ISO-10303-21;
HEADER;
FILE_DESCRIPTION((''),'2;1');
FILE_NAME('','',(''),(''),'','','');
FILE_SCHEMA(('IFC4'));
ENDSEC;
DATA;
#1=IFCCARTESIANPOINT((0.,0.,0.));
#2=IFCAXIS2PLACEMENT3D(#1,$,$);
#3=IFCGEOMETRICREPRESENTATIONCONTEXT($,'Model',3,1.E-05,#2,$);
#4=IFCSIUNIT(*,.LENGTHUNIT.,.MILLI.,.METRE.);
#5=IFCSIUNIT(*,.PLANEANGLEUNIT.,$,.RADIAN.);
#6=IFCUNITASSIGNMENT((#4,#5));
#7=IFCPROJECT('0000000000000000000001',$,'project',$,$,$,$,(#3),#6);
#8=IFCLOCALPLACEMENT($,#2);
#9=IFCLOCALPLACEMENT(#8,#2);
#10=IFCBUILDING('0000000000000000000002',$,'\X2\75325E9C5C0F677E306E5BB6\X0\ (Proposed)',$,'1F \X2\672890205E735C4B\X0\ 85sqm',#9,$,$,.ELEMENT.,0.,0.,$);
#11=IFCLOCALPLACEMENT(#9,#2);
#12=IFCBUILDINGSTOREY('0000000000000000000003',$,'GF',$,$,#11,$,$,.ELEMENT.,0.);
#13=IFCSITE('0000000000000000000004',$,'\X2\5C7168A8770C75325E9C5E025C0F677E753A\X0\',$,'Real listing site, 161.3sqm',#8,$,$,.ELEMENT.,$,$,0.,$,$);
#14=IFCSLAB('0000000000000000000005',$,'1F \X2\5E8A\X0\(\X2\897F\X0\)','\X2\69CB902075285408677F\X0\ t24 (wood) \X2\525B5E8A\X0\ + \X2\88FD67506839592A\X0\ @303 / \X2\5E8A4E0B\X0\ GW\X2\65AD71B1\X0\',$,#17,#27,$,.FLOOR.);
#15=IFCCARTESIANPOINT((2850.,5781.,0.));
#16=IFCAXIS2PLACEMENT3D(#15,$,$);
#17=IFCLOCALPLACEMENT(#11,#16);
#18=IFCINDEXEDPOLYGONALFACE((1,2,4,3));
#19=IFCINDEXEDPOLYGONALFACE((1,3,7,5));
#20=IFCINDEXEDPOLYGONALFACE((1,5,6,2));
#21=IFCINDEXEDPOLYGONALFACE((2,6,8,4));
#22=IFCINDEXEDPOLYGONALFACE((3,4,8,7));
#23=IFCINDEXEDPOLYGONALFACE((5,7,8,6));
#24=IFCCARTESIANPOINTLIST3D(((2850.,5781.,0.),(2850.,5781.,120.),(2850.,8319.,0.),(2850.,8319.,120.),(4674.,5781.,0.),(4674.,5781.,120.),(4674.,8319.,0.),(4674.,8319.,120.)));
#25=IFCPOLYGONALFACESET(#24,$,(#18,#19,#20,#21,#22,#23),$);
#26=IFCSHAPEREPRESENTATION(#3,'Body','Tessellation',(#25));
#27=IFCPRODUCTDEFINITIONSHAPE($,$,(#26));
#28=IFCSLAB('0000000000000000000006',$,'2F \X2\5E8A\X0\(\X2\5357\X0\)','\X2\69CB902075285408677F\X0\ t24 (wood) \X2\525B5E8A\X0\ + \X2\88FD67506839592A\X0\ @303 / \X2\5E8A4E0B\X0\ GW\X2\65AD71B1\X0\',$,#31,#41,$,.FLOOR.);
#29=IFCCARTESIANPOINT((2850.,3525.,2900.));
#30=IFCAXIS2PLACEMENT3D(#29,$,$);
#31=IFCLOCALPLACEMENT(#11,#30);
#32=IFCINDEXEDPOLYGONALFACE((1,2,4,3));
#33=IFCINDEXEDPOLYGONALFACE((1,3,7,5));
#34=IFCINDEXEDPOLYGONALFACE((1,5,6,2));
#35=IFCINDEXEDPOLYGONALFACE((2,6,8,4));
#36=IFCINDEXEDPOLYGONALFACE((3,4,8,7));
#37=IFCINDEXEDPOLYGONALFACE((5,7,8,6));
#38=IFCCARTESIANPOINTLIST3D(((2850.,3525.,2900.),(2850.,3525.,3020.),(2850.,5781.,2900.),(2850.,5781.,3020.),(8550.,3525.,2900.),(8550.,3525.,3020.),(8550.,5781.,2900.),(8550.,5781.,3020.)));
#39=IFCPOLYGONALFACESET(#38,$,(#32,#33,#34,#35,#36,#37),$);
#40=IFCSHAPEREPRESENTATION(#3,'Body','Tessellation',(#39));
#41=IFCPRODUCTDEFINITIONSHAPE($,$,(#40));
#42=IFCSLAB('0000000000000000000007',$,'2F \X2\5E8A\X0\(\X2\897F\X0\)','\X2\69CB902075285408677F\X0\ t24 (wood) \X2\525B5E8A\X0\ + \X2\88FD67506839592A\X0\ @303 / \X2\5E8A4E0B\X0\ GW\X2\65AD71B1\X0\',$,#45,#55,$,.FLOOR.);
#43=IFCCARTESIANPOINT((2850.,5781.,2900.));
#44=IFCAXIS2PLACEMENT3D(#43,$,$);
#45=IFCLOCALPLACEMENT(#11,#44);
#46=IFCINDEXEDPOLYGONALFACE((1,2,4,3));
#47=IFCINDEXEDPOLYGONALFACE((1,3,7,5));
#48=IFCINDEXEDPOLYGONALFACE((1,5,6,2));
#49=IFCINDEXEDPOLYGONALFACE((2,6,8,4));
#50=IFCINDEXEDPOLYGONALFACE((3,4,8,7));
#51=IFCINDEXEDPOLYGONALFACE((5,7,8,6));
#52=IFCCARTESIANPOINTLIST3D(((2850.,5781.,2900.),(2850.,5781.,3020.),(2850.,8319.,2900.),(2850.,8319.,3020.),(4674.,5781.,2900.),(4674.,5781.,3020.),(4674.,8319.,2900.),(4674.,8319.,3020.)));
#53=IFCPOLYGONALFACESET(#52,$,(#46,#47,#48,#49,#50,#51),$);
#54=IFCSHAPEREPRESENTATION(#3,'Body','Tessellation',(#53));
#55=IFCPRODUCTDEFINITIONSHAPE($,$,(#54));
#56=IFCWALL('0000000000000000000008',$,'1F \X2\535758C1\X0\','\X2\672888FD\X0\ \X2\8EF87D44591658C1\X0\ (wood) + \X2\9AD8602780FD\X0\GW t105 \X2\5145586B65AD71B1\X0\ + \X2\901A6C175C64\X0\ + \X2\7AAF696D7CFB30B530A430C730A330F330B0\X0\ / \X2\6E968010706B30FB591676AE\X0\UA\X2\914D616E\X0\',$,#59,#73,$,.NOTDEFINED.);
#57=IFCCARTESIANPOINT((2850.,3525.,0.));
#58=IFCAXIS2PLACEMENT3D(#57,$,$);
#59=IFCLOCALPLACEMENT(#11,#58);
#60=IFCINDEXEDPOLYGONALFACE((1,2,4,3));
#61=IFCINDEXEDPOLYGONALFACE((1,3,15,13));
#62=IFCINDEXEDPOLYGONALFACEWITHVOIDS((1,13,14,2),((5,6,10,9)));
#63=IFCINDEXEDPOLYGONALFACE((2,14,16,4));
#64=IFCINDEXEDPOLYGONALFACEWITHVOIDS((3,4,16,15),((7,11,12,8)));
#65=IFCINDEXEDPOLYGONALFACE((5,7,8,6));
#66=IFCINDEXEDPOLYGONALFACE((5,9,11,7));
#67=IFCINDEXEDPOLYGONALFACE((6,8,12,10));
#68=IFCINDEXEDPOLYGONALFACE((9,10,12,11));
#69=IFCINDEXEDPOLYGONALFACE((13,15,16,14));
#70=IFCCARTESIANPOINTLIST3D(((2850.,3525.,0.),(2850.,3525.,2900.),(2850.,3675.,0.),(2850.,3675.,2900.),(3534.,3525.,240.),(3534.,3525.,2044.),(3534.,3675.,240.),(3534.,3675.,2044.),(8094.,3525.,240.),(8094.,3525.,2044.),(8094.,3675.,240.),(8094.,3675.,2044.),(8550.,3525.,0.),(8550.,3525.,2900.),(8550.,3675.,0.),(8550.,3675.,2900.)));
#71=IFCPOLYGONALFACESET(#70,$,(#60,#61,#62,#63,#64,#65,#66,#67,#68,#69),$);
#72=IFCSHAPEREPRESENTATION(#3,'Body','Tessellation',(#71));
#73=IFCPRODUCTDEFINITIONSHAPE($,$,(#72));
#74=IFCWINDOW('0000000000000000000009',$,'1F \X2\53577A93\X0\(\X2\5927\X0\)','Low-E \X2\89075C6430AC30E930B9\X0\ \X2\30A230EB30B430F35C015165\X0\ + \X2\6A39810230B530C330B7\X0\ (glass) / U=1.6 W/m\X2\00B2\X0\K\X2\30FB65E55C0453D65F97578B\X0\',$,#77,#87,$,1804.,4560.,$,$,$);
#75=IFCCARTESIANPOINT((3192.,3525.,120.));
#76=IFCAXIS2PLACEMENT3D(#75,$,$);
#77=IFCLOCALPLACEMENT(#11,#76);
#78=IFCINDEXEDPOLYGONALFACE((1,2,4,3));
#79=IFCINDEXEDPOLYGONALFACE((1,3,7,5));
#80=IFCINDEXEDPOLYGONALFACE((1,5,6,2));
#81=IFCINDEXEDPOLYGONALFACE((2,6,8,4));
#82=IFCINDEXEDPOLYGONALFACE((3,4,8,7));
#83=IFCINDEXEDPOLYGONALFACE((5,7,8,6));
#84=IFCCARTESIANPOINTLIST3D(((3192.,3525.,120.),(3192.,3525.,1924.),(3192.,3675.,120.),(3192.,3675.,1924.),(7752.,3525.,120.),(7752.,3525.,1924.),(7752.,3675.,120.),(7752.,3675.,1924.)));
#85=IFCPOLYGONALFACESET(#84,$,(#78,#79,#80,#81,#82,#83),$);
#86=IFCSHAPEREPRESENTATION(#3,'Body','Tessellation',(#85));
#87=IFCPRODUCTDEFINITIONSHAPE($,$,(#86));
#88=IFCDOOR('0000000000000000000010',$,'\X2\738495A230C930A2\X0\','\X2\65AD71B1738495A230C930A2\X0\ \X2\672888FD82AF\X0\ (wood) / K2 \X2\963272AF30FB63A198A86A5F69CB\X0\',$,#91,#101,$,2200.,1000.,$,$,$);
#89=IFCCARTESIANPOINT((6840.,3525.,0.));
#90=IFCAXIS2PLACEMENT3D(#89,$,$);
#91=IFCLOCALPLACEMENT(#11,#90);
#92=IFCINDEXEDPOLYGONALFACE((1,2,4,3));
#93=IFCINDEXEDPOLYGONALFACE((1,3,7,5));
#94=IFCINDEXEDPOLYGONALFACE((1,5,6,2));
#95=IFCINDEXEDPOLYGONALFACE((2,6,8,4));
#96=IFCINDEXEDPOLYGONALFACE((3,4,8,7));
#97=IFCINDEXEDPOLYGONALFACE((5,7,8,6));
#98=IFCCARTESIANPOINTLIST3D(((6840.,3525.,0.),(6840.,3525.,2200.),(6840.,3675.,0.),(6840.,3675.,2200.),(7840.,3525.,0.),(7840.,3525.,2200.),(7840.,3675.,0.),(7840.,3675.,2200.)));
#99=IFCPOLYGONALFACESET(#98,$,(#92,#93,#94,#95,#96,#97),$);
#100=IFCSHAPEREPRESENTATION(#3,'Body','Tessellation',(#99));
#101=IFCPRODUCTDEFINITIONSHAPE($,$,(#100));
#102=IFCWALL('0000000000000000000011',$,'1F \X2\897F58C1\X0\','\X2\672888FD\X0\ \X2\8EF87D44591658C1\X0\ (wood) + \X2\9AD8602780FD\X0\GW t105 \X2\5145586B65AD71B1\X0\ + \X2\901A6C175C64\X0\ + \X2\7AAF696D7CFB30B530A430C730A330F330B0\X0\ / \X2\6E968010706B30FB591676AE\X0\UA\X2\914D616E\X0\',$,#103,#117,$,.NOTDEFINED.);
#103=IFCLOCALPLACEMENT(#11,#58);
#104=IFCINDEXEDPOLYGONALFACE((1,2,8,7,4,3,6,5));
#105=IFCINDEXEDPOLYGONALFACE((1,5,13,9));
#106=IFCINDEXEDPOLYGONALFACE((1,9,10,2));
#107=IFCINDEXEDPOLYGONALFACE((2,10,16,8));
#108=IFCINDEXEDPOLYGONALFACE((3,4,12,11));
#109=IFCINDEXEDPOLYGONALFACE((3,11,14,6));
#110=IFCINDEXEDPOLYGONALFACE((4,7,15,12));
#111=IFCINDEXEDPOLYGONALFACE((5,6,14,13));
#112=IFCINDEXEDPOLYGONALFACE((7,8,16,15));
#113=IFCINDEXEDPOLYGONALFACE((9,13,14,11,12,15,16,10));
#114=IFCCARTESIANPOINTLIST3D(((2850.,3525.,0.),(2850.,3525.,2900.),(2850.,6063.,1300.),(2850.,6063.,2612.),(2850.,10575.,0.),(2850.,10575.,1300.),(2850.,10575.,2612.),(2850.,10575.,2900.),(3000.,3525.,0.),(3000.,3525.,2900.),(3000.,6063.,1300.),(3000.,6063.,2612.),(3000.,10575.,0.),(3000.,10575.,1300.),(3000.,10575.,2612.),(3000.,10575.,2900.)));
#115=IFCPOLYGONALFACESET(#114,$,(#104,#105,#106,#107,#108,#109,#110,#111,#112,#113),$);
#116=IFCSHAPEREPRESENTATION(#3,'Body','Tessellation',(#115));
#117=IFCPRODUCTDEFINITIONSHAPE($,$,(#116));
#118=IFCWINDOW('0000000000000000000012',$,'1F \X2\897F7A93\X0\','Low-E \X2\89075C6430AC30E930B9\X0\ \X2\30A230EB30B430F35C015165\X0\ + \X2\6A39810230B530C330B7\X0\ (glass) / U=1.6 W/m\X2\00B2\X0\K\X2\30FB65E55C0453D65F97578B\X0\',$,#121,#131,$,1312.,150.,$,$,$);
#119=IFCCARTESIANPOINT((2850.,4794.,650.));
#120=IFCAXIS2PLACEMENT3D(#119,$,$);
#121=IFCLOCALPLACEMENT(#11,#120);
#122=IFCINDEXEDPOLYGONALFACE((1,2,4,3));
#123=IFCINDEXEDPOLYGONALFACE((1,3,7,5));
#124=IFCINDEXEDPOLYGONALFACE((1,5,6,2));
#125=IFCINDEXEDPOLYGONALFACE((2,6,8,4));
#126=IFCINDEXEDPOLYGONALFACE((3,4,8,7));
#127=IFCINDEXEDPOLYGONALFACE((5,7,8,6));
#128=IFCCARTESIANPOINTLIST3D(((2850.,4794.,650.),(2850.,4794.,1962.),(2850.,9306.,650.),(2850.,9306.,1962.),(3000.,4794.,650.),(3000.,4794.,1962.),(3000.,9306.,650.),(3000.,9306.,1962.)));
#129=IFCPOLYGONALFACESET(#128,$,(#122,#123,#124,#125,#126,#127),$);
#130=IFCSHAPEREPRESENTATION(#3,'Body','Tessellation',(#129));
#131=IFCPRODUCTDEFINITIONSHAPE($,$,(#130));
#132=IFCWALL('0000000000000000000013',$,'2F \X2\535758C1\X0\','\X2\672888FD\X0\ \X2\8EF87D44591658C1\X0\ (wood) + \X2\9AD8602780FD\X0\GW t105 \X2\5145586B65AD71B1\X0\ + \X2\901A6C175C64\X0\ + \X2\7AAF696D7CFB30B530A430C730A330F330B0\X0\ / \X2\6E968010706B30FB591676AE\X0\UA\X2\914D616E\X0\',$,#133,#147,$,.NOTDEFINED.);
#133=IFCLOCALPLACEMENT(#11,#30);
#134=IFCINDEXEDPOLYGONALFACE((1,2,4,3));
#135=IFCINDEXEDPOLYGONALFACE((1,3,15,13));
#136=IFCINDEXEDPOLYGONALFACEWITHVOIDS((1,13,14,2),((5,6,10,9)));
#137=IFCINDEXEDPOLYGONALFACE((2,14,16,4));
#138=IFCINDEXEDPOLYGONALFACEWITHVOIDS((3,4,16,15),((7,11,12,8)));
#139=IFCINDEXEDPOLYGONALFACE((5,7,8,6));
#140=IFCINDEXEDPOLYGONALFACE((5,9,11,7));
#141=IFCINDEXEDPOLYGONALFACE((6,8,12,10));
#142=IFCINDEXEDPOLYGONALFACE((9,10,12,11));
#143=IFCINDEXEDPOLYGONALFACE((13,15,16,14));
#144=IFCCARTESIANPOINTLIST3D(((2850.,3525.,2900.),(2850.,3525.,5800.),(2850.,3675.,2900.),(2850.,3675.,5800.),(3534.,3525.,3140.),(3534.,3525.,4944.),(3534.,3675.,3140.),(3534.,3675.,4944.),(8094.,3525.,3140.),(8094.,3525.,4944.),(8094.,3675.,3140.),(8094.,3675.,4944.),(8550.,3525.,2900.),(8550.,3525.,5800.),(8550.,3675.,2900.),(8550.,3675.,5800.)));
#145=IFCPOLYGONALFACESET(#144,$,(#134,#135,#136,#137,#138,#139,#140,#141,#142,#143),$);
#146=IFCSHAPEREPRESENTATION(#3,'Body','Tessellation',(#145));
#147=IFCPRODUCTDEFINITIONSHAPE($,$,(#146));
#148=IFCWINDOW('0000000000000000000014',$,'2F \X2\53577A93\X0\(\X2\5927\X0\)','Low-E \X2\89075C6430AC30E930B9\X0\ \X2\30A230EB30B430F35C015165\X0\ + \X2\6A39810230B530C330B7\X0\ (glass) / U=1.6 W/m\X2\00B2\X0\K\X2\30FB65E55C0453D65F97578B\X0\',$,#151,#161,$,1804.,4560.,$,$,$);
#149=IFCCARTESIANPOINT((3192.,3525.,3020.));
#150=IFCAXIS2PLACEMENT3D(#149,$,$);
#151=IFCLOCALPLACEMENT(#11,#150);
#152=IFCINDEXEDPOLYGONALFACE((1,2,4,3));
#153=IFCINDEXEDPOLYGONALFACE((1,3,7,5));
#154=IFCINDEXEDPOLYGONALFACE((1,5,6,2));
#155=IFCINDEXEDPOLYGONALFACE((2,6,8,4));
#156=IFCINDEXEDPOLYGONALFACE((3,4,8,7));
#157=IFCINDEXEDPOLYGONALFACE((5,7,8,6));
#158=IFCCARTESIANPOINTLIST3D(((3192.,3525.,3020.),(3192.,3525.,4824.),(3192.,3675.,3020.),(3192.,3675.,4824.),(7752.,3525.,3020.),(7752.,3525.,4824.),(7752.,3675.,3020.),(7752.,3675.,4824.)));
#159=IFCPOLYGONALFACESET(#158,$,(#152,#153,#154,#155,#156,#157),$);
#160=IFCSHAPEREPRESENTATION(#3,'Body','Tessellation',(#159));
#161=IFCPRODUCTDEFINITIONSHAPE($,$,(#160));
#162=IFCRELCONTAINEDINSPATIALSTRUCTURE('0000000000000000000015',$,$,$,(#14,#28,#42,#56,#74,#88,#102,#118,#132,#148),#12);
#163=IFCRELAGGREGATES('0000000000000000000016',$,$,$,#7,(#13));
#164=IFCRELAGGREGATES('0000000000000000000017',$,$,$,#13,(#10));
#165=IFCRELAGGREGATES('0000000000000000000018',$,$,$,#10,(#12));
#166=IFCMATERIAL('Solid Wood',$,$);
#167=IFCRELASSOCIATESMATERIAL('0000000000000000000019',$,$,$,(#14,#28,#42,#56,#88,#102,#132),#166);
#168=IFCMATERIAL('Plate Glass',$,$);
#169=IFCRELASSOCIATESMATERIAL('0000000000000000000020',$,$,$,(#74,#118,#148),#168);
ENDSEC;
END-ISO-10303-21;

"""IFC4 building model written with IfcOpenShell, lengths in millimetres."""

from ifc_helpers import new_model, si_unit, frame, frame_2d, origin, place, context, project, spatial, rectangle, extrude, material, element, fill, save


model = new_model("IFC4")

# Units and contexts
model_context = context("Model", 3, precision=1e-05, world=origin())
ifc_project = project(units=[si_unit("LENGTHUNIT", "METRE", prefix="MILLI"), si_unit("PLANEANGLEUNIT", "RADIAN")], contexts=[model_context])

# Site, building, storey
site_placement = place(None, origin())
site = spatial("IfcSite", under=ifc_project, at=site_placement, Name="山梨県甲府市小松町", ObjectType="Real listing site, 161.3sqm", CompositionType="ELEMENT", RefElevation=0.0)
building_placement = place(site_placement, origin())
building = spatial("IfcBuilding", under=site, at=building_placement, Name="甲府小松の家 (Proposed)", ObjectType="1F 木造平屋 85sqm", CompositionType="ELEMENT", ElevationOfRefHeight=0.0, ElevationOfTerrain=0.0)
storey_placement = place(building_placement, origin())
storey = spatial("IfcBuildingStorey", under=building, at=storey_placement, Name="GF", CompositionType="ELEMENT", Elevation=0.0)

# Slabs
ifc_material_1 = material(Name="Solid Wood")
slab_1_placement = place(storey_placement, frame((2850.0, 5781.0, 0.0)))
element("IfcSlab", 1, at=slab_1_placement, inside=storey, material=ifc_material_1, Name="1F 床(西)", Description="構造用合板 t24 (wood) 剛床 + 製材根太 @303 / 床下 GW断熱", PredefinedType="FLOOR", context=model_context, shape_type="SweptSolid", body=[
    extrude(rectangle(XDim=1824.0, YDim=2538.0, at=frame_2d((912.0, 1269.0))), frame((2850.0, 5781.0, 0.0)), (0.0, 0.0, 1.0), 120.0),
])
slab_2_placement = place(storey_placement, frame((2850.0, 3525.0, 2900.0)))
element("IfcSlab", 2, at=slab_2_placement, inside=storey, material=ifc_material_1, Name="2F 床(南)", Description="構造用合板 t24 (wood) 剛床 + 製材根太 @303 / 床下 GW断熱", PredefinedType="FLOOR", context=model_context, shape_type="SweptSolid", body=[
    extrude(rectangle(XDim=5700.0, YDim=2256.0, at=frame_2d((2850.0, 1128.0))), frame((2850.0, 3525.0, 2900.0)), (0.0, 0.0, 1.0), 120.0),
])
slab_3_placement = place(storey_placement, frame((2850.0, 5781.0, 2900.0)))
element("IfcSlab", 3, at=slab_3_placement, inside=storey, material=ifc_material_1, Name="2F 床(西)", Description="構造用合板 t24 (wood) 剛床 + 製材根太 @303 / 床下 GW断熱", PredefinedType="FLOOR", context=model_context, shape_type="SweptSolid", body=[
    extrude(rectangle(XDim=1824.0, YDim=2538.0, at=frame_2d((912.0, 1269.0))), frame((2850.0, 5781.0, 2900.0)), (0.0, 0.0, 1.0), 120.0),
])

# Wall, openings, window, door
wall_1_placement = place(storey_placement, frame((2850.0, 3525.0, 0.0)))
wall_1 = element("IfcWall", 4, at=wall_1_placement, inside=storey, material=ifc_material_1, Name="1F 南壁", Description="木製 軸組外壁 (wood) + 高性能GW t105 充填断熱 + 通気層 + 窯業系サイディング / 準耐火・外皮UA配慮", PredefinedType="NOTDEFINED", context=model_context, shape_type="SweptSolid", body=[
    extrude(rectangle(XDim=5700.0, YDim=150.0, at=frame_2d((2850.0, 75.0))), frame((2850.0, 3525.0, 0.0)), (0.0, 0.0, 1.0), 2900.0),
])
opening_1_placement = place(storey_placement, frame((3192.0, 3525.0, 120.0)))
opening_1 = element("IfcOpeningElement", 5, at=opening_1_placement, cuts=wall_1, PredefinedType="NOTDEFINED", context=model_context, shape_type="SweptSolid", body=[
    extrude(rectangle(XDim=4560.0, YDim=150.0, at=frame_2d((2280.0, 75.0))), frame((3192.0, 3525.0, 120.0)), (0.0, 0.0, 1.0), 1804.0),
])
opening_2_placement = place(storey_placement, frame((6840.0, 3525.0, 0.0)))
opening_2 = element("IfcOpeningElement", 6, at=opening_2_placement, cuts=wall_1, PredefinedType="NOTDEFINED", context=model_context, shape_type="SweptSolid", body=[
    extrude(rectangle(XDim=1000.0, YDim=150.0, at=frame_2d((500.0, 75.0))), frame((6840.0, 3525.0, 0.0)), (0.0, 0.0, 1.0), 2200.0),
])
ifc_material_2 = material(Name="Plate Glass")
window_1_placement = place(storey_placement, frame((3192.0, 3525.0, 120.0)))
window_1 = element("IfcWindow", 7, at=window_1_placement, inside=storey, material=ifc_material_2, Name="1F 南窓(大)", Description="Low-E 複層ガラス アルゴン封入 + 樹脂サッシ (glass) / U=1.6 W/m²K・日射取得型", OverallHeight=1804.0, OverallWidth=4560.0, context=model_context, shape_type="SweptSolid", body=[
    extrude(rectangle(XDim=4560.0, YDim=150.0, at=frame_2d((2280.0, 75.0))), frame((3192.0, 3525.0, 120.0)), (0.0, 0.0, 1.0), 1804.0),
])
fill(opening_1, window_1)
door_placement = place(storey_placement, frame((6840.0, 3525.0, 0.0)))
door = element("IfcDoor", 8, at=door_placement, inside=storey, material=ifc_material_1, Name="玄関ドア", Description="断熱玄関ドア 木製芯 (wood) / K2 防犯・採風機構", OverallHeight=2200.0, OverallWidth=1000.0, context=model_context, shape_type="SweptSolid", body=[
    extrude(rectangle(XDim=1000.0, YDim=150.0, at=frame_2d((500.0, 75.0))), frame((6840.0, 3525.0, 0.0)), (0.0, 0.0, 1.0), 2200.0),
])
fill(opening_2, door)

# Walls, openings, windows
wall_2_placement = place(storey_placement, frame((2850.0, 3525.0, 0.0)))
wall_2 = element("IfcWall", 9, at=wall_2_placement, inside=storey, material=ifc_material_1, Name="1F 西壁", Description="木製 軸組外壁 (wood) + 高性能GW t105 充填断熱 + 通気層 + 窯業系サイディング / 準耐火・外皮UA配慮", PredefinedType="NOTDEFINED", context=model_context, shape_type="SweptSolid", body=[
    extrude(rectangle(XDim=150.0, YDim=7050.0, at=frame_2d((75.0, 3525.0))), frame((2850.0, 3525.0, 0.0)), (0.0, 0.0, 1.0), 2900.0),
])
opening_3_placement = place(storey_placement, frame((2850.0, 4794.0, 650.0)))
opening_3 = element("IfcOpeningElement", 10, at=opening_3_placement, cuts=wall_2, PredefinedType="NOTDEFINED", context=model_context, shape_type="SweptSolid", body=[
    extrude(rectangle(XDim=150.0, YDim=4512.0, at=frame_2d((75.0, 2256.0))), frame((2850.0, 4794.0, 650.0)), (0.0, 0.0, 1.0), 1312.0),
])
window_2_placement = place(storey_placement, frame((2850.0, 4794.0, 650.0)))
window_2 = element("IfcWindow", 11, at=window_2_placement, inside=storey, material=ifc_material_2, Name="1F 西窓", Description="Low-E 複層ガラス アルゴン封入 + 樹脂サッシ (glass) / U=1.6 W/m²K・日射取得型", OverallHeight=1312.0, OverallWidth=150.0, context=model_context, shape_type="SweptSolid", body=[
    extrude(rectangle(XDim=150.0, YDim=4512.0, at=frame_2d((75.0, 2256.0))), frame((2850.0, 4794.0, 650.0)), (0.0, 0.0, 1.0), 1312.0),
])
fill(opening_3, window_2)
wall_3_placement = place(storey_placement, frame((2850.0, 3525.0, 2900.0)))
wall_3 = element("IfcWall", 12, at=wall_3_placement, inside=storey, material=ifc_material_1, Name="2F 南壁", Description="木製 軸組外壁 (wood) + 高性能GW t105 充填断熱 + 通気層 + 窯業系サイディング / 準耐火・外皮UA配慮", PredefinedType="NOTDEFINED", context=model_context, shape_type="SweptSolid", body=[
    extrude(rectangle(XDim=5700.0, YDim=150.0, at=frame_2d((2850.0, 75.0))), frame((2850.0, 3525.0, 2900.0)), (0.0, 0.0, 1.0), 2900.0),
])
opening_4_placement = place(storey_placement, frame((3192.0, 3525.0, 3020.0)))
opening_4 = element("IfcOpeningElement", 13, at=opening_4_placement, cuts=wall_3, PredefinedType="NOTDEFINED", context=model_context, shape_type="SweptSolid", body=[
    extrude(rectangle(XDim=4560.0, YDim=150.0, at=frame_2d((2280.0, 75.0))), frame((3192.0, 3525.0, 3020.0)), (0.0, 0.0, 1.0), 1804.0),
])
window_3_placement = place(storey_placement, frame((3192.0, 3525.0, 3020.0)))
window_3 = element("IfcWindow", 14, at=window_3_placement, inside=storey, material=ifc_material_2, Name="2F 南窓(大)", Description="Low-E 複層ガラス アルゴン封入 + 樹脂サッシ (glass) / U=1.6 W/m²K・日射取得型", OverallHeight=1804.0, OverallWidth=4560.0, context=model_context, shape_type="SweptSolid", body=[
    extrude(rectangle(XDim=4560.0, YDim=150.0, at=frame_2d((2280.0, 75.0))), frame((3192.0, 3525.0, 3020.0)), (0.0, 0.0, 1.0), 1804.0),
])
fill(opening_4, window_3)

save(model, "model.ifc")
